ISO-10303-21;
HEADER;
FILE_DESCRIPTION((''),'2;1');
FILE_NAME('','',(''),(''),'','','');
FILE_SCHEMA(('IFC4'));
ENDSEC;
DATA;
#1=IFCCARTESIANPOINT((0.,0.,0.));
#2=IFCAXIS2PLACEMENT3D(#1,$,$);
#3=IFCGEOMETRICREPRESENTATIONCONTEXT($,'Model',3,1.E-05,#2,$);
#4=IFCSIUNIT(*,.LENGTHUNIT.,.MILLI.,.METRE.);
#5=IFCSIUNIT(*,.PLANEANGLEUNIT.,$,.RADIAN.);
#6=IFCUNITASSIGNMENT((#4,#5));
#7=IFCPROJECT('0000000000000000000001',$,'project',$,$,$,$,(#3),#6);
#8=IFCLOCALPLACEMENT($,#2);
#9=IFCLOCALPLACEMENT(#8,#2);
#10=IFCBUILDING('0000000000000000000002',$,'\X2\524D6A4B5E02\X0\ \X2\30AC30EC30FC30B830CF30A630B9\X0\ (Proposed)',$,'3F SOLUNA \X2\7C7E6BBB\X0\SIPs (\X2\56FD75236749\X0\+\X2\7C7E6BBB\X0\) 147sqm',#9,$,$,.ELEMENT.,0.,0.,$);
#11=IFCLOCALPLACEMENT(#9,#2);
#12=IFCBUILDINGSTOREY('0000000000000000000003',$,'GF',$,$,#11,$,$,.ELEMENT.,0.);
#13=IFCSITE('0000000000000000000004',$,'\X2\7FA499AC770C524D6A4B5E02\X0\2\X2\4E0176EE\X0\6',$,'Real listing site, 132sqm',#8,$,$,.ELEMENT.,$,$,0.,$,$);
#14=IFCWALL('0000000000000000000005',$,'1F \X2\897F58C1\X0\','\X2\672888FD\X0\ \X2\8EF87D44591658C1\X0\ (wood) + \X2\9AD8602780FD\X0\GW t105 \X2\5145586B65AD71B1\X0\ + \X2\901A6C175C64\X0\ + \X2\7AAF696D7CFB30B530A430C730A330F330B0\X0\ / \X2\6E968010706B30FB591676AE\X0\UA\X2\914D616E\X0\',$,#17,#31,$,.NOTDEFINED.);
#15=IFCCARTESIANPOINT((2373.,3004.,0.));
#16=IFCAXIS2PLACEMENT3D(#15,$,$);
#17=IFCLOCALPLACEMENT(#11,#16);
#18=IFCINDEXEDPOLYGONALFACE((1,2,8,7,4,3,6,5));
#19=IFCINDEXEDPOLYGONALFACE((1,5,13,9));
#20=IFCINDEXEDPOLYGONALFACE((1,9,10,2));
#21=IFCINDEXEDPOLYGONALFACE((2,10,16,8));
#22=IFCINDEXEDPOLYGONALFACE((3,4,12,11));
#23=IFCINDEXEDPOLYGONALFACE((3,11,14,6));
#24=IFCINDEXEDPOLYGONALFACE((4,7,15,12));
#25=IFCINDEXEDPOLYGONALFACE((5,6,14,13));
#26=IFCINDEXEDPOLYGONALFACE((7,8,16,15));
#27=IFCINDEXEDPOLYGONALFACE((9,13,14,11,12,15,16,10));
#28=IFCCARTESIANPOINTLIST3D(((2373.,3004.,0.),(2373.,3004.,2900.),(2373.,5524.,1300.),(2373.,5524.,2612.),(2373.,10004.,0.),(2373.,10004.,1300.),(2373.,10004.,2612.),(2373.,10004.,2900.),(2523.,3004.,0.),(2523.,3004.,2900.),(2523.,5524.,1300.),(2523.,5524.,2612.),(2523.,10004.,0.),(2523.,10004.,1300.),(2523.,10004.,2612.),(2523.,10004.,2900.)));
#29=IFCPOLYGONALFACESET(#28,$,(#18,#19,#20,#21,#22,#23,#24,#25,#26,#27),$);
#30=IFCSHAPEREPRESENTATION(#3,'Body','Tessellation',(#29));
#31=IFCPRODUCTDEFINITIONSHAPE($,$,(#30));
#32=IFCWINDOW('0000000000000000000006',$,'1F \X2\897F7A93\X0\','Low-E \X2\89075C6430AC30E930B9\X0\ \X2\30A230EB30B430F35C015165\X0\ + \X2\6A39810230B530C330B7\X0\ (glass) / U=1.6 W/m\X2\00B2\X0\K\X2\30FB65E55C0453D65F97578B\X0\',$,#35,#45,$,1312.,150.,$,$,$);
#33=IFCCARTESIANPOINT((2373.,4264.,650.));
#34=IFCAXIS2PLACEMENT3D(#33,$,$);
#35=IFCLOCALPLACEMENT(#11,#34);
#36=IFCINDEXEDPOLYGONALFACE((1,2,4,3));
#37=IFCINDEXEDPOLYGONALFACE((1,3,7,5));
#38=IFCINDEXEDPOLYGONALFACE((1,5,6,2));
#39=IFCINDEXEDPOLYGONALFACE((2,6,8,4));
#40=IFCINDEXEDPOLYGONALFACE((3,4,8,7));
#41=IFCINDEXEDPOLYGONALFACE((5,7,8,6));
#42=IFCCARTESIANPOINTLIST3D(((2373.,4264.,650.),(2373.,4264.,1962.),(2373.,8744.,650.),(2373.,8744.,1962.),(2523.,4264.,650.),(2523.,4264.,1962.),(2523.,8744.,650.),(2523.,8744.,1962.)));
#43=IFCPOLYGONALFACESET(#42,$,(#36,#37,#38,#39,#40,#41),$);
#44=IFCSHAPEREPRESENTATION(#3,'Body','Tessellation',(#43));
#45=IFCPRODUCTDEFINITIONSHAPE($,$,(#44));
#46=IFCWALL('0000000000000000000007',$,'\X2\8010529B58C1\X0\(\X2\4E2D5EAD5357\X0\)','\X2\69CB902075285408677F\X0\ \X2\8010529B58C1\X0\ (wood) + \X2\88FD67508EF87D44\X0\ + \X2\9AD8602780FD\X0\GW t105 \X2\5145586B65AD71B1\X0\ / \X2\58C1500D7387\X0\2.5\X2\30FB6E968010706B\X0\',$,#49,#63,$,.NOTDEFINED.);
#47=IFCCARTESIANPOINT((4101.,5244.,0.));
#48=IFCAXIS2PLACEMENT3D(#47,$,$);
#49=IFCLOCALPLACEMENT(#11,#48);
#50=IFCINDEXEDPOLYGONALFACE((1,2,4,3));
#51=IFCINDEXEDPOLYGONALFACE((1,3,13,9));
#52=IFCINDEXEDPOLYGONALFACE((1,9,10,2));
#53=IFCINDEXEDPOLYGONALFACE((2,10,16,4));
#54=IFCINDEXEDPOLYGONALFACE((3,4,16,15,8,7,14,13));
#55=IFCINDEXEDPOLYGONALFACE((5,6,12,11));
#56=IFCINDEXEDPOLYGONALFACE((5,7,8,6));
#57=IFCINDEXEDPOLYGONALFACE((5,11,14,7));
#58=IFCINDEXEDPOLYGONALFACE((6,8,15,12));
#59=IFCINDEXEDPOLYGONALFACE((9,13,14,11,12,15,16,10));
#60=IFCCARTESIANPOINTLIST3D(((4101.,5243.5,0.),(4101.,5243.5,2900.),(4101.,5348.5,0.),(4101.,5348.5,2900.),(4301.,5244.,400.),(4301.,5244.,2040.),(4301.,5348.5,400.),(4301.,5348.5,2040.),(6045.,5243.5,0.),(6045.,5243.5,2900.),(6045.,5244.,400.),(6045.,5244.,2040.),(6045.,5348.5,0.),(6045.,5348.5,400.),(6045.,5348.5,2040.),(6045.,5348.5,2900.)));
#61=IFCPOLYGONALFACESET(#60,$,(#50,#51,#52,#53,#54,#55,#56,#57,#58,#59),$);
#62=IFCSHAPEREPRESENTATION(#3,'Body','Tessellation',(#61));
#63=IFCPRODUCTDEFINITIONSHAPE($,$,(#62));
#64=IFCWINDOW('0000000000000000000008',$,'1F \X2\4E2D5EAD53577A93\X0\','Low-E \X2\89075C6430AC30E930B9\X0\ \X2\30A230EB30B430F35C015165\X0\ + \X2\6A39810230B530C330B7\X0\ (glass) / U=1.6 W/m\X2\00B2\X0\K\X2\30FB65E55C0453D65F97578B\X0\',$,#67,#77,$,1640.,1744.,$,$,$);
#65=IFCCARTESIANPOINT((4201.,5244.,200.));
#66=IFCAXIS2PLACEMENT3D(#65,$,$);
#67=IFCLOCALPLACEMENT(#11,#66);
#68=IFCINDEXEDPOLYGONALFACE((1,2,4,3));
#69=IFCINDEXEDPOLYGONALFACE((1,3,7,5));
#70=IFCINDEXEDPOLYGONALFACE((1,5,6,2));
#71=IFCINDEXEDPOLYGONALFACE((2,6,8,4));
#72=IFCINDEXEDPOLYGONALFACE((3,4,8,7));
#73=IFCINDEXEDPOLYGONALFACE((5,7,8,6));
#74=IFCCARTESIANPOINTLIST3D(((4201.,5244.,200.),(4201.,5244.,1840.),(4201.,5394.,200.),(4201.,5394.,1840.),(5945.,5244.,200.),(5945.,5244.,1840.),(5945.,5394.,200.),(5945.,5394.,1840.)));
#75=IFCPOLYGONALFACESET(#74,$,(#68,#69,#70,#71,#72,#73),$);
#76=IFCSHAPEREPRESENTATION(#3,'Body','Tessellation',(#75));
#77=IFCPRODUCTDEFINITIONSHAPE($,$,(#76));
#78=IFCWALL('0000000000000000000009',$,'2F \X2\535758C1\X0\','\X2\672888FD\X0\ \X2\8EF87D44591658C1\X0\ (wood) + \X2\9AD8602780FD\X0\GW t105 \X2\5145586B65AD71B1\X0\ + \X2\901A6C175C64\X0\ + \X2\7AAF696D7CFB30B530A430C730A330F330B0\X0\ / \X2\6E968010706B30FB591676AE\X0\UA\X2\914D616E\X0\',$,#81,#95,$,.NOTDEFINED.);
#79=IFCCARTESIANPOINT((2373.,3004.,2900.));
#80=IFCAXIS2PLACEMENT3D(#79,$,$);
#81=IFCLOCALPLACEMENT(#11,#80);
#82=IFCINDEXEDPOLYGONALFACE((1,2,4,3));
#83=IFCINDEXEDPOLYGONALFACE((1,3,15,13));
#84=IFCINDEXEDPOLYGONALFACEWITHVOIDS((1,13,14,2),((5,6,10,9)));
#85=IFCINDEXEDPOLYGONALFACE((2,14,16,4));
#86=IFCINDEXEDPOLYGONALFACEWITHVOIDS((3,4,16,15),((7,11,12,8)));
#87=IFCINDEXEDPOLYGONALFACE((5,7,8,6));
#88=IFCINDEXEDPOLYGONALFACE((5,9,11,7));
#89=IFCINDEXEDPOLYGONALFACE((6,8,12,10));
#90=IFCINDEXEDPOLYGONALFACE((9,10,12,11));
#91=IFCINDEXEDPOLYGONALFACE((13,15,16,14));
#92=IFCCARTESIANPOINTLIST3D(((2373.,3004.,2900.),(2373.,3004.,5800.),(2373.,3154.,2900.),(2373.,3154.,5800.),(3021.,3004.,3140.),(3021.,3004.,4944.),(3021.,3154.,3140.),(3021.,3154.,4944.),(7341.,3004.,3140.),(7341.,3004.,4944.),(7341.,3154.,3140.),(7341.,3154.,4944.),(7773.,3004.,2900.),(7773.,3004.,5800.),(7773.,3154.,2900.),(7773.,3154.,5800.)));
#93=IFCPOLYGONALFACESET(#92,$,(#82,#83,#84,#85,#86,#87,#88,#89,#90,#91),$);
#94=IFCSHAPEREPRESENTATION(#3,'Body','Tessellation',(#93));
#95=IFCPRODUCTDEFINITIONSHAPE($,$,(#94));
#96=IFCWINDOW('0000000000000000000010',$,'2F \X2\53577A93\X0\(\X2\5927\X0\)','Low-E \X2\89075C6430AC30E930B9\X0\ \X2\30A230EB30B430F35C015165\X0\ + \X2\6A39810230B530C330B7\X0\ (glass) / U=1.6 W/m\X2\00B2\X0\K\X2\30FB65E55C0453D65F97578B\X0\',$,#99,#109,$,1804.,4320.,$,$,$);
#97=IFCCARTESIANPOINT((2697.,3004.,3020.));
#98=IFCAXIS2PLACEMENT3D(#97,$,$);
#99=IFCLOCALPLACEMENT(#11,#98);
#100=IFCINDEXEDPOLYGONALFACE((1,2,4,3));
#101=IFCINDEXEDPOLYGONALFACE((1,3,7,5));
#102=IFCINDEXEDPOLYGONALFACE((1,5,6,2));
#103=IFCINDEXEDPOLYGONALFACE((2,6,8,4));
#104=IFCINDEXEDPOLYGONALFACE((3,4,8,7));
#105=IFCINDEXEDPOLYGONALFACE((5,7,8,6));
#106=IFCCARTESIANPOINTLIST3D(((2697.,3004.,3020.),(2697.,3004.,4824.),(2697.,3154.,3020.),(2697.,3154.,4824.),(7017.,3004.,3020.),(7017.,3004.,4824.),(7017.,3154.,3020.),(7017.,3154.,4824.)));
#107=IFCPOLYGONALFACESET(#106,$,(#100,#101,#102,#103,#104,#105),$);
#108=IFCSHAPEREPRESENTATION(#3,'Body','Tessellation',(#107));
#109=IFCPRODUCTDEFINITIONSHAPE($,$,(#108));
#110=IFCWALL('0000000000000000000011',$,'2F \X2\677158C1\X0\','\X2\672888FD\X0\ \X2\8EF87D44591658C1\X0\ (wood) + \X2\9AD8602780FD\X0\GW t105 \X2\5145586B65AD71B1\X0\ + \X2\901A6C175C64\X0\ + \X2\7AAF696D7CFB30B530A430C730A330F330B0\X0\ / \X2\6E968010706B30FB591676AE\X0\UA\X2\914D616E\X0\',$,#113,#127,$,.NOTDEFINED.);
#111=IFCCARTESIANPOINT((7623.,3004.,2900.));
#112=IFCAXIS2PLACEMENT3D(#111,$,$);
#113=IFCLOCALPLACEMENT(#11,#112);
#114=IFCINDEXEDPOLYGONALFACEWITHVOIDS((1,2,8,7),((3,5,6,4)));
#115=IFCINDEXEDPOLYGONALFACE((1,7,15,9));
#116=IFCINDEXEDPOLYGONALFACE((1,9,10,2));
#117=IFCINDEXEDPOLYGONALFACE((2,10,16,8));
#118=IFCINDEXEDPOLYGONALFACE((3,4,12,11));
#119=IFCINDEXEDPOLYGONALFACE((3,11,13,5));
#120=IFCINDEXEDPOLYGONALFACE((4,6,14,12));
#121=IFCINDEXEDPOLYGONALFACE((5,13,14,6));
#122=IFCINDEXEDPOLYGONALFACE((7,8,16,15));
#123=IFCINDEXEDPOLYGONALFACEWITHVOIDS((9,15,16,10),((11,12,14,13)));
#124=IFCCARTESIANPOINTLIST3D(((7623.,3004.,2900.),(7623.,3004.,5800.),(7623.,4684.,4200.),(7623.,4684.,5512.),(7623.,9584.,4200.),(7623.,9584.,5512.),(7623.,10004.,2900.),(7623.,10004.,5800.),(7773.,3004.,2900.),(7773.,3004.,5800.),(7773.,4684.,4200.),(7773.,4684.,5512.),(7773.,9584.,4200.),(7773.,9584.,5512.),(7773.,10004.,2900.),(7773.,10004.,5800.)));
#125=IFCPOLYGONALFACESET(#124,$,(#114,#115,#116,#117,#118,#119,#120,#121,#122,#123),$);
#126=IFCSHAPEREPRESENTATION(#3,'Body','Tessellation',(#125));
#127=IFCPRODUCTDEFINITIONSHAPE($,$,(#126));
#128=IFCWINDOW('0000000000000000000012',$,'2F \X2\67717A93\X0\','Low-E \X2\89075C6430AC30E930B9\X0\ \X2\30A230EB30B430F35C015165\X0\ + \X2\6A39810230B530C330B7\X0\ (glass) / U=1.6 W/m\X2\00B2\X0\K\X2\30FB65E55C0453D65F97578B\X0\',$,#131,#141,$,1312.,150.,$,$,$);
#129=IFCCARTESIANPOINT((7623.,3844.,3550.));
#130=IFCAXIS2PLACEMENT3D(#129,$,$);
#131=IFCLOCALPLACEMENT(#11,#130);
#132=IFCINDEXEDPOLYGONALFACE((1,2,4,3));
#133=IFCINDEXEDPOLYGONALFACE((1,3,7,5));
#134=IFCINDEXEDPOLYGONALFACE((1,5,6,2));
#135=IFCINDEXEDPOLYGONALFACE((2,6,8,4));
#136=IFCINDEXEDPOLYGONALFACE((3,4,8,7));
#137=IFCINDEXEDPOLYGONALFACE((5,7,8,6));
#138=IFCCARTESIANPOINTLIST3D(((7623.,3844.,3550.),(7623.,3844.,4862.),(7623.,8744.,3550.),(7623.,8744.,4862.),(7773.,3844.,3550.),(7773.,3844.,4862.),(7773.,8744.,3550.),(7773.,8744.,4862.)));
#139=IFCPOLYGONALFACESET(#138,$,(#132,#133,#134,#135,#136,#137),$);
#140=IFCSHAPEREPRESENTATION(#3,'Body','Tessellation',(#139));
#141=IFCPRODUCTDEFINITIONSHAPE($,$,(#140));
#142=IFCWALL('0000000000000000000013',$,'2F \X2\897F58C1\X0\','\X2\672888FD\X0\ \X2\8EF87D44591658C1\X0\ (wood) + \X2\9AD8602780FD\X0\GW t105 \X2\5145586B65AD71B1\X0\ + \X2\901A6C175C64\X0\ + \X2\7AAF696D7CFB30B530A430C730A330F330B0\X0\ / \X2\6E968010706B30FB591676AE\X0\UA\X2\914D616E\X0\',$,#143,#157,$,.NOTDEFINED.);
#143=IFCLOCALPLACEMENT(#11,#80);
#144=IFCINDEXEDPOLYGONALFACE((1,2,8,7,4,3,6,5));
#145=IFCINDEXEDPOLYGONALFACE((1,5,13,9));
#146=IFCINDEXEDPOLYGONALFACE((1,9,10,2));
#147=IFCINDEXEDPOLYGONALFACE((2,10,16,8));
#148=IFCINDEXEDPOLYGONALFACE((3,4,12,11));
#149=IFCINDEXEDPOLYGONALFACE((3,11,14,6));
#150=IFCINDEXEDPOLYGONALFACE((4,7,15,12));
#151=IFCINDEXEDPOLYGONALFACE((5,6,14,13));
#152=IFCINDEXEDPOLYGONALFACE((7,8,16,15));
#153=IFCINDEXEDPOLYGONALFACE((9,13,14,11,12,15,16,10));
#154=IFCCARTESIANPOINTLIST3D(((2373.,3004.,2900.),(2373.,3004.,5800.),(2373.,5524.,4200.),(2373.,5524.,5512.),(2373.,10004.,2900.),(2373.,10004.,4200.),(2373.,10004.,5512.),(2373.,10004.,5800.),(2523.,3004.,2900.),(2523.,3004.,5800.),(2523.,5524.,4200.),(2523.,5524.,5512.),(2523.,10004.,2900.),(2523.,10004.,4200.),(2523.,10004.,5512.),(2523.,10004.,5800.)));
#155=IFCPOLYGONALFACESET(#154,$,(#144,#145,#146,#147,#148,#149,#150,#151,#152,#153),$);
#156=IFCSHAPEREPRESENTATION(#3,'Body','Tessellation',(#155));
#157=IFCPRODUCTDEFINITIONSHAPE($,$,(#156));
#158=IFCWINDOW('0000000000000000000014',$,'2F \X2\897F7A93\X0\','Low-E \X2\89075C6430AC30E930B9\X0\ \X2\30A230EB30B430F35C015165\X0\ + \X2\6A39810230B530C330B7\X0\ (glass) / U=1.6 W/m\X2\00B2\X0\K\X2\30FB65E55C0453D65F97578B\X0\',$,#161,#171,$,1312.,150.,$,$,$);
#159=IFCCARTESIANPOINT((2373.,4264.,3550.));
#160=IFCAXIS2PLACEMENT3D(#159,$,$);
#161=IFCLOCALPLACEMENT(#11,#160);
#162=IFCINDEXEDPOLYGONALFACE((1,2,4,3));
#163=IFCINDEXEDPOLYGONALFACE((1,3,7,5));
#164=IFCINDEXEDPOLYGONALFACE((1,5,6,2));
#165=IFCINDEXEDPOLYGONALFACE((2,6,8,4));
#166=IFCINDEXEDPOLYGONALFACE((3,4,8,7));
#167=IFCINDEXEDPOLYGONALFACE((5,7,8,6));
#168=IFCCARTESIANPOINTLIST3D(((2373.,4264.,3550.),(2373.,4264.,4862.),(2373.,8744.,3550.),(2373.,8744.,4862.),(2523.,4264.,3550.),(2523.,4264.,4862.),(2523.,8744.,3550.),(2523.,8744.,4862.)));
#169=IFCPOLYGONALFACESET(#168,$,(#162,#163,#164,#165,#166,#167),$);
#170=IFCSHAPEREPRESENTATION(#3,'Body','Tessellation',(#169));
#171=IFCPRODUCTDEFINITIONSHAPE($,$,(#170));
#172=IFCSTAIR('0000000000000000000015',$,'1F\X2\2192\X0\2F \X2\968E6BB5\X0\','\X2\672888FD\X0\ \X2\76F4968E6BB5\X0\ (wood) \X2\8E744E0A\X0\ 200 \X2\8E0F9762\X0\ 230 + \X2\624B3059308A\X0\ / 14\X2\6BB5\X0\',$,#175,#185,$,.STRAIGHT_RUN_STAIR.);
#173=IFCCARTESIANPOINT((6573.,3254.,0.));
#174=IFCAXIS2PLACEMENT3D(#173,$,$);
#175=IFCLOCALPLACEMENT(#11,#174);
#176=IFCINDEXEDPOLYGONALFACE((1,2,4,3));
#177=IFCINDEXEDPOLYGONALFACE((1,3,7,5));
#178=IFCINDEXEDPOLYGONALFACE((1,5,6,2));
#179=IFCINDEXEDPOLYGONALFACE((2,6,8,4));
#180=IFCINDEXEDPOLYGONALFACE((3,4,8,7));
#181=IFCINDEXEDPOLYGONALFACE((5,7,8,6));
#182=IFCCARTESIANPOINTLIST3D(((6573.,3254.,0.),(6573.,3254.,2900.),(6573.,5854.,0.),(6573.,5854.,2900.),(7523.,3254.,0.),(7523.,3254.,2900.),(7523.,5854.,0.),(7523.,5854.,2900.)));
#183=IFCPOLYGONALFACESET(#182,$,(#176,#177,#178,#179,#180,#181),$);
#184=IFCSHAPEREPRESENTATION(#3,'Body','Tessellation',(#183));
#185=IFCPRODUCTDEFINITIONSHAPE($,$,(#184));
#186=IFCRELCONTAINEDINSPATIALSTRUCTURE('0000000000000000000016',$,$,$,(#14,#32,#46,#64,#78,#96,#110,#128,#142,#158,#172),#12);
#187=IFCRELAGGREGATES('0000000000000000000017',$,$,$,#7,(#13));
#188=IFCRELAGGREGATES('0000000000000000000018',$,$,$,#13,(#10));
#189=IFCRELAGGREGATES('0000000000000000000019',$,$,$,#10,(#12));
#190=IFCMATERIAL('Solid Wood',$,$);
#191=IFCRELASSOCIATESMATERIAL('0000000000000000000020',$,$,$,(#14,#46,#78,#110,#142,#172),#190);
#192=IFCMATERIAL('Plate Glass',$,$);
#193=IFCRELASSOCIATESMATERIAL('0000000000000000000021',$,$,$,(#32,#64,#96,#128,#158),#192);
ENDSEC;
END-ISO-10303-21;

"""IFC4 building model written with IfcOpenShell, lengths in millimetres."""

from ifc_helpers import new_model, si_unit, frame, frame_2d, origin, place, context, project, spatial, rectangle, extrude, material, element, fill, save


model = new_model("IFC4")

# Units and contexts
model_context = context("Model", 3, precision=1e-05, world=origin())
ifc_project = project(units=[si_unit("LENGTHUNIT", "METRE", prefix="MILLI"), si_unit("PLANEANGLEUNIT", "RADIAN")], contexts=[model_context])

# Site, building, storey
site_placement = place(None, origin())
site = spatial("IfcSite", under=ifc_project, at=site_placement, Name="群馬県前橋市2丁目6", ObjectType="Real listing site, 132sqm", CompositionType="ELEMENT", RefElevation=0.0)
building_placement = place(site_placement, origin())
building = spatial("IfcBuilding", under=site, at=building_placement, Name="前橋市 ガレージハウス (Proposed)", ObjectType="3F SOLUNA 籾殻SIPs (国産杉+籾殻) 147sqm", CompositionType="ELEMENT", ElevationOfRefHeight=0.0, ElevationOfTerrain=0.0)
storey_placement = place(building_placement, origin())
storey = spatial("IfcBuildingStorey", under=building, at=storey_placement, Name="GF", CompositionType="ELEMENT", Elevation=0.0)

# Shared definitions
ifc_material_1 = material(Name="Solid Wood")

# Shared definitions
ifc_material_2 = material(Name="Plate Glass")

# Walls, openings, windows
wall_1_placement = place(storey_placement, frame((2373.0, 3004.0, 0.0)))
wall_1 = element("IfcWall", 1, at=wall_1_placement, inside=storey, material=ifc_material_1, Name="1F 西壁", Description="木製 軸組外壁 (wood) + 高性能GW t105 充填断熱 + 通気層 + 窯業系サイディング / 準耐火・外皮UA配慮", PredefinedType="NOTDEFINED", context=model_context, shape_type="SweptSolid", body=[
    extrude(rectangle(XDim=150.0, YDim=7000.0, at=frame_2d((75.0, 3500.0))), frame((2373.0, 3004.0, 0.0)), (0.0, 0.0, 1.0), 2900.0),
])
opening_1_placement = place(storey_placement, frame((2373.0, 4264.0, 650.0)))
opening_1 = element("IfcOpeningElement", 2, at=opening_1_placement, cuts=wall_1, PredefinedType="NOTDEFINED", context=model_context, shape_type="SweptSolid", body=[
    extrude(rectangle(XDim=150.0, YDim=4480.0, at=frame_2d((75.0, 2240.0))), frame((2373.0, 4264.0, 650.0)), (0.0, 0.0, 1.0), 1312.0),
])
window_1_placement = place(storey_placement, frame((2373.0, 4264.0, 650.0)))
window_1 = element("IfcWindow", 3, at=window_1_placement, inside=storey, material=ifc_material_2, Name="1F 西窓", Description="Low-E 複層ガラス アルゴン封入 + 樹脂サッシ (glass) / U=1.6 W/m²K・日射取得型", OverallHeight=1312.0, OverallWidth=150.0, context=model_context, shape_type="SweptSolid", body=[
    extrude(rectangle(XDim=150.0, YDim=4480.0, at=frame_2d((75.0, 2240.0))), frame((2373.0, 4264.0, 650.0)), (0.0, 0.0, 1.0), 1312.0),
])
fill(opening_1, window_1)
wall_2_placement = place(storey_placement, frame((4101.0, 5244.0, 0.0)))
wall_2 = element("IfcWall", 4, at=wall_2_placement, inside=storey, material=ifc_material_1, Name="耐力壁(中庭南)", Description="構造用合板 耐力壁 (wood) + 製材軸組 + 高性能GW t105 充填断熱 / 壁倍率2.5・準耐火", PredefinedType="NOTDEFINED", context=model_context, shape_type="SweptSolid", body=[
    extrude(rectangle(XDim=1944.0, YDim=105.0, at=frame_2d((972.0, 52.0))), frame((4101.0, 5244.0, 0.0)), (0.0, 0.0, 1.0), 2900.0),
])
opening_2_placement = place(storey_placement, frame((4201.0, 5244.0, 200.0)))
opening_2 = element("IfcOpeningElement", 5, at=opening_2_placement, cuts=wall_2, PredefinedType="NOTDEFINED", context=model_context, shape_type="SweptSolid", body=[
    extrude(rectangle(XDim=1744.0, YDim=150.0, at=frame_2d((872.0, 75.0))), frame((4201.0, 5244.0, 200.0)), (0.0, 0.0, 1.0), 1640.0),
])
window_2_placement = place(storey_placement, frame((4201.0, 5244.0, 200.0)))
window_2 = element("IfcWindow", 6, at=window_2_placement, inside=storey, material=ifc_material_2, Name="1F 中庭南窓", Description="Low-E 複層ガラス アルゴン封入 + 樹脂サッシ (glass) / U=1.6 W/m²K・日射取得型", OverallHeight=1640.0, OverallWidth=1744.0, context=model_context, shape_type="SweptSolid", body=[
    extrude(rectangle(XDim=1744.0, YDim=150.0, at=frame_2d((872.0, 75.0))), frame((4201.0, 5244.0, 200.0)), (0.0, 0.0, 1.0), 1640.0),
])
fill(opening_2, window_2)
wall_3_placement = place(storey_placement, frame((2373.0, 3004.0, 2900.0)))
wall_3 = element("IfcWall", 7, at=wall_3_placement, inside=storey, material=ifc_material_1, Name="2F 南壁", Description="木製 軸組外壁 (wood) + 高性能GW t105 充填断熱 + 通気層 + 窯業系サイディング / 準耐火・外皮UA配慮", PredefinedType="NOTDEFINED", context=model_context, shape_type="SweptSolid", body=[
    extrude(rectangle(XDim=5400.0, YDim=150.0, at=frame_2d((2700.0, 75.0))), frame((2373.0, 3004.0, 2900.0)), (0.0, 0.0, 1.0), 2900.0),
])
opening_3_placement = place(storey_placement, frame((2697.0, 3004.0, 3020.0)))
opening_3 = element("IfcOpeningElement", 8, at=opening_3_placement, cuts=wall_3, PredefinedType="NOTDEFINED", context=model_context, shape_type="SweptSolid", body=[
    extrude(rectangle(XDim=4320.0, YDim=150.0, at=frame_2d((2160.0, 75.0))), frame((2697.0, 3004.0, 3020.0)), (0.0, 0.0, 1.0), 1804.0),
])
window_3_placement = place(storey_placement, frame((2697.0, 3004.0, 3020.0)))
window_3 = element("IfcWindow", 9, at=window_3_placement, inside=storey, material=ifc_material_2, Name="2F 南窓(大)", Description="Low-E 複層ガラス アルゴン封入 + 樹脂サッシ (glass) / U=1.6 W/m²K・日射取得型", OverallHeight=1804.0, OverallWidth=4320.0, context=model_context, shape_type="SweptSolid", body=[
    extrude(rectangle(XDim=4320.0, YDim=150.0, at=frame_2d((2160.0, 75.0))), frame((2697.0, 3004.0, 3020.0)), (0.0, 0.0, 1.0), 1804.0),
])
fill(opening_3, window_3)
wall_4_placement = place(storey_placement, frame((7623.0, 3004.0, 2900.0)))
wall_4 = element("IfcWall", 10, at=wall_4_placement, inside=storey, material=ifc_material_1, Name="2F 東壁", Description="木製 軸組外壁 (wood) + 高性能GW t105 充填断熱 + 通気層 + 窯業系サイディング / 準耐火・外皮UA配慮", PredefinedType="NOTDEFINED", context=model_context, shape_type="SweptSolid", body=[
    extrude(rectangle(XDim=150.0, YDim=7000.0, at=frame_2d((75.0, 3500.0))), frame((7623.0, 3004.0, 2900.0)), (0.0, 0.0, 1.0), 2900.0),
])
opening_4_placement = place(storey_placement, frame((7623.0, 3844.0, 3550.0)))
opening_4 = element("IfcOpeningElement", 11, at=opening_4_placement, cuts=wall_4, PredefinedType="NOTDEFINED", context=model_context, shape_type="SweptSolid", body=[
    extrude(rectangle(XDim=150.0, YDim=4900.0, at=frame_2d((75.0, 2450.0))), frame((7623.0, 3844.0, 3550.0)), (0.0, 0.0, 1.0), 1312.0),
])
window_4_placement = place(storey_placement, frame((7623.0, 3844.0, 3550.0)))
window_4 = element("IfcWindow", 12, at=window_4_placement, inside=storey, material=ifc_material_2, Name="2F 東窓", Description="Low-E 複層ガラス アルゴン封入 + 樹脂サッシ (glass) / U=1.6 W/m²K・日射取得型", OverallHeight=1312.0, OverallWidth=150.0, context=model_context, shape_type="SweptSolid", body=[
    extrude(rectangle(XDim=150.0, YDim=4900.0, at=frame_2d((75.0, 2450.0))), frame((7623.0, 3844.0, 3550.0)), (0.0, 0.0, 1.0), 1312.0),
])
fill(opening_4, window_4)
wall_5_placement = place(storey_placement, frame((2373.0, 3004.0, 2900.0)))
wall_5 = element("IfcWall", 13, at=wall_5_placement, inside=storey, material=ifc_material_1, Name="2F 西壁", Description="木製 軸組外壁 (wood) + 高性能GW t105 充填断熱 + 通気層 + 窯業系サイディング / 準耐火・外皮UA配慮", PredefinedType="NOTDEFINED", context=model_context, shape_type="SweptSolid", body=[
    extrude(rectangle(XDim=150.0, YDim=7000.0, at=frame_2d((75.0, 3500.0))), frame((2373.0, 3004.0, 2900.0)), (0.0, 0.0, 1.0), 2900.0),
])
opening_5_placement = place(storey_placement, frame((2373.0, 4264.0, 3550.0)))
opening_5 = element("IfcOpeningElement", 14, at=opening_5_placement, cuts=wall_5, PredefinedType="NOTDEFINED", context=model_context, shape_type="SweptSolid", body=[
    extrude(rectangle(XDim=150.0, YDim=4480.0, at=frame_2d((75.0, 2240.0))), frame((2373.0, 4264.0, 3550.0)), (0.0, 0.0, 1.0), 1312.0),
])
window_5_placement = place(storey_placement, frame((2373.0, 4264.0, 3550.0)))
window_5 = element("IfcWindow", 15, at=window_5_placement, inside=storey, material=ifc_material_2, Name="2F 西窓", Description="Low-E 複層ガラス アルゴン封入 + 樹脂サッシ (glass) / U=1.6 W/m²K・日射取得型", OverallHeight=1312.0, OverallWidth=150.0, context=model_context, shape_type="SweptSolid", body=[
    extrude(rectangle(XDim=150.0, YDim=4480.0, at=frame_2d((75.0, 2240.0))), frame((2373.0, 4264.0, 3550.0)), (0.0, 0.0, 1.0), 1312.0),
])
fill(opening_5, window_5)

# Stair
stair_1_placement = place(storey_placement, frame((6573.0, 3254.0, 0.0)))
element("IfcStair", 16, at=stair_1_placement, inside=storey, material=ifc_material_1, Name="1F→2F 階段", Description="木製 直階段 (wood) 蹴上 200 踏面 230 + 手すり / 14段", PredefinedType="STRAIGHT_RUN_STAIR", context=model_context, shape_type="SweptSolid", body=[
    extrude(rectangle(XDim=950.0, YDim=2600.0, at=frame_2d((475.0, 1300.0))), frame((6573.0, 3254.0, 0.0)), (0.0, 0.0, 1.0), 2900.0),
])

save(model, "model.ifc")
